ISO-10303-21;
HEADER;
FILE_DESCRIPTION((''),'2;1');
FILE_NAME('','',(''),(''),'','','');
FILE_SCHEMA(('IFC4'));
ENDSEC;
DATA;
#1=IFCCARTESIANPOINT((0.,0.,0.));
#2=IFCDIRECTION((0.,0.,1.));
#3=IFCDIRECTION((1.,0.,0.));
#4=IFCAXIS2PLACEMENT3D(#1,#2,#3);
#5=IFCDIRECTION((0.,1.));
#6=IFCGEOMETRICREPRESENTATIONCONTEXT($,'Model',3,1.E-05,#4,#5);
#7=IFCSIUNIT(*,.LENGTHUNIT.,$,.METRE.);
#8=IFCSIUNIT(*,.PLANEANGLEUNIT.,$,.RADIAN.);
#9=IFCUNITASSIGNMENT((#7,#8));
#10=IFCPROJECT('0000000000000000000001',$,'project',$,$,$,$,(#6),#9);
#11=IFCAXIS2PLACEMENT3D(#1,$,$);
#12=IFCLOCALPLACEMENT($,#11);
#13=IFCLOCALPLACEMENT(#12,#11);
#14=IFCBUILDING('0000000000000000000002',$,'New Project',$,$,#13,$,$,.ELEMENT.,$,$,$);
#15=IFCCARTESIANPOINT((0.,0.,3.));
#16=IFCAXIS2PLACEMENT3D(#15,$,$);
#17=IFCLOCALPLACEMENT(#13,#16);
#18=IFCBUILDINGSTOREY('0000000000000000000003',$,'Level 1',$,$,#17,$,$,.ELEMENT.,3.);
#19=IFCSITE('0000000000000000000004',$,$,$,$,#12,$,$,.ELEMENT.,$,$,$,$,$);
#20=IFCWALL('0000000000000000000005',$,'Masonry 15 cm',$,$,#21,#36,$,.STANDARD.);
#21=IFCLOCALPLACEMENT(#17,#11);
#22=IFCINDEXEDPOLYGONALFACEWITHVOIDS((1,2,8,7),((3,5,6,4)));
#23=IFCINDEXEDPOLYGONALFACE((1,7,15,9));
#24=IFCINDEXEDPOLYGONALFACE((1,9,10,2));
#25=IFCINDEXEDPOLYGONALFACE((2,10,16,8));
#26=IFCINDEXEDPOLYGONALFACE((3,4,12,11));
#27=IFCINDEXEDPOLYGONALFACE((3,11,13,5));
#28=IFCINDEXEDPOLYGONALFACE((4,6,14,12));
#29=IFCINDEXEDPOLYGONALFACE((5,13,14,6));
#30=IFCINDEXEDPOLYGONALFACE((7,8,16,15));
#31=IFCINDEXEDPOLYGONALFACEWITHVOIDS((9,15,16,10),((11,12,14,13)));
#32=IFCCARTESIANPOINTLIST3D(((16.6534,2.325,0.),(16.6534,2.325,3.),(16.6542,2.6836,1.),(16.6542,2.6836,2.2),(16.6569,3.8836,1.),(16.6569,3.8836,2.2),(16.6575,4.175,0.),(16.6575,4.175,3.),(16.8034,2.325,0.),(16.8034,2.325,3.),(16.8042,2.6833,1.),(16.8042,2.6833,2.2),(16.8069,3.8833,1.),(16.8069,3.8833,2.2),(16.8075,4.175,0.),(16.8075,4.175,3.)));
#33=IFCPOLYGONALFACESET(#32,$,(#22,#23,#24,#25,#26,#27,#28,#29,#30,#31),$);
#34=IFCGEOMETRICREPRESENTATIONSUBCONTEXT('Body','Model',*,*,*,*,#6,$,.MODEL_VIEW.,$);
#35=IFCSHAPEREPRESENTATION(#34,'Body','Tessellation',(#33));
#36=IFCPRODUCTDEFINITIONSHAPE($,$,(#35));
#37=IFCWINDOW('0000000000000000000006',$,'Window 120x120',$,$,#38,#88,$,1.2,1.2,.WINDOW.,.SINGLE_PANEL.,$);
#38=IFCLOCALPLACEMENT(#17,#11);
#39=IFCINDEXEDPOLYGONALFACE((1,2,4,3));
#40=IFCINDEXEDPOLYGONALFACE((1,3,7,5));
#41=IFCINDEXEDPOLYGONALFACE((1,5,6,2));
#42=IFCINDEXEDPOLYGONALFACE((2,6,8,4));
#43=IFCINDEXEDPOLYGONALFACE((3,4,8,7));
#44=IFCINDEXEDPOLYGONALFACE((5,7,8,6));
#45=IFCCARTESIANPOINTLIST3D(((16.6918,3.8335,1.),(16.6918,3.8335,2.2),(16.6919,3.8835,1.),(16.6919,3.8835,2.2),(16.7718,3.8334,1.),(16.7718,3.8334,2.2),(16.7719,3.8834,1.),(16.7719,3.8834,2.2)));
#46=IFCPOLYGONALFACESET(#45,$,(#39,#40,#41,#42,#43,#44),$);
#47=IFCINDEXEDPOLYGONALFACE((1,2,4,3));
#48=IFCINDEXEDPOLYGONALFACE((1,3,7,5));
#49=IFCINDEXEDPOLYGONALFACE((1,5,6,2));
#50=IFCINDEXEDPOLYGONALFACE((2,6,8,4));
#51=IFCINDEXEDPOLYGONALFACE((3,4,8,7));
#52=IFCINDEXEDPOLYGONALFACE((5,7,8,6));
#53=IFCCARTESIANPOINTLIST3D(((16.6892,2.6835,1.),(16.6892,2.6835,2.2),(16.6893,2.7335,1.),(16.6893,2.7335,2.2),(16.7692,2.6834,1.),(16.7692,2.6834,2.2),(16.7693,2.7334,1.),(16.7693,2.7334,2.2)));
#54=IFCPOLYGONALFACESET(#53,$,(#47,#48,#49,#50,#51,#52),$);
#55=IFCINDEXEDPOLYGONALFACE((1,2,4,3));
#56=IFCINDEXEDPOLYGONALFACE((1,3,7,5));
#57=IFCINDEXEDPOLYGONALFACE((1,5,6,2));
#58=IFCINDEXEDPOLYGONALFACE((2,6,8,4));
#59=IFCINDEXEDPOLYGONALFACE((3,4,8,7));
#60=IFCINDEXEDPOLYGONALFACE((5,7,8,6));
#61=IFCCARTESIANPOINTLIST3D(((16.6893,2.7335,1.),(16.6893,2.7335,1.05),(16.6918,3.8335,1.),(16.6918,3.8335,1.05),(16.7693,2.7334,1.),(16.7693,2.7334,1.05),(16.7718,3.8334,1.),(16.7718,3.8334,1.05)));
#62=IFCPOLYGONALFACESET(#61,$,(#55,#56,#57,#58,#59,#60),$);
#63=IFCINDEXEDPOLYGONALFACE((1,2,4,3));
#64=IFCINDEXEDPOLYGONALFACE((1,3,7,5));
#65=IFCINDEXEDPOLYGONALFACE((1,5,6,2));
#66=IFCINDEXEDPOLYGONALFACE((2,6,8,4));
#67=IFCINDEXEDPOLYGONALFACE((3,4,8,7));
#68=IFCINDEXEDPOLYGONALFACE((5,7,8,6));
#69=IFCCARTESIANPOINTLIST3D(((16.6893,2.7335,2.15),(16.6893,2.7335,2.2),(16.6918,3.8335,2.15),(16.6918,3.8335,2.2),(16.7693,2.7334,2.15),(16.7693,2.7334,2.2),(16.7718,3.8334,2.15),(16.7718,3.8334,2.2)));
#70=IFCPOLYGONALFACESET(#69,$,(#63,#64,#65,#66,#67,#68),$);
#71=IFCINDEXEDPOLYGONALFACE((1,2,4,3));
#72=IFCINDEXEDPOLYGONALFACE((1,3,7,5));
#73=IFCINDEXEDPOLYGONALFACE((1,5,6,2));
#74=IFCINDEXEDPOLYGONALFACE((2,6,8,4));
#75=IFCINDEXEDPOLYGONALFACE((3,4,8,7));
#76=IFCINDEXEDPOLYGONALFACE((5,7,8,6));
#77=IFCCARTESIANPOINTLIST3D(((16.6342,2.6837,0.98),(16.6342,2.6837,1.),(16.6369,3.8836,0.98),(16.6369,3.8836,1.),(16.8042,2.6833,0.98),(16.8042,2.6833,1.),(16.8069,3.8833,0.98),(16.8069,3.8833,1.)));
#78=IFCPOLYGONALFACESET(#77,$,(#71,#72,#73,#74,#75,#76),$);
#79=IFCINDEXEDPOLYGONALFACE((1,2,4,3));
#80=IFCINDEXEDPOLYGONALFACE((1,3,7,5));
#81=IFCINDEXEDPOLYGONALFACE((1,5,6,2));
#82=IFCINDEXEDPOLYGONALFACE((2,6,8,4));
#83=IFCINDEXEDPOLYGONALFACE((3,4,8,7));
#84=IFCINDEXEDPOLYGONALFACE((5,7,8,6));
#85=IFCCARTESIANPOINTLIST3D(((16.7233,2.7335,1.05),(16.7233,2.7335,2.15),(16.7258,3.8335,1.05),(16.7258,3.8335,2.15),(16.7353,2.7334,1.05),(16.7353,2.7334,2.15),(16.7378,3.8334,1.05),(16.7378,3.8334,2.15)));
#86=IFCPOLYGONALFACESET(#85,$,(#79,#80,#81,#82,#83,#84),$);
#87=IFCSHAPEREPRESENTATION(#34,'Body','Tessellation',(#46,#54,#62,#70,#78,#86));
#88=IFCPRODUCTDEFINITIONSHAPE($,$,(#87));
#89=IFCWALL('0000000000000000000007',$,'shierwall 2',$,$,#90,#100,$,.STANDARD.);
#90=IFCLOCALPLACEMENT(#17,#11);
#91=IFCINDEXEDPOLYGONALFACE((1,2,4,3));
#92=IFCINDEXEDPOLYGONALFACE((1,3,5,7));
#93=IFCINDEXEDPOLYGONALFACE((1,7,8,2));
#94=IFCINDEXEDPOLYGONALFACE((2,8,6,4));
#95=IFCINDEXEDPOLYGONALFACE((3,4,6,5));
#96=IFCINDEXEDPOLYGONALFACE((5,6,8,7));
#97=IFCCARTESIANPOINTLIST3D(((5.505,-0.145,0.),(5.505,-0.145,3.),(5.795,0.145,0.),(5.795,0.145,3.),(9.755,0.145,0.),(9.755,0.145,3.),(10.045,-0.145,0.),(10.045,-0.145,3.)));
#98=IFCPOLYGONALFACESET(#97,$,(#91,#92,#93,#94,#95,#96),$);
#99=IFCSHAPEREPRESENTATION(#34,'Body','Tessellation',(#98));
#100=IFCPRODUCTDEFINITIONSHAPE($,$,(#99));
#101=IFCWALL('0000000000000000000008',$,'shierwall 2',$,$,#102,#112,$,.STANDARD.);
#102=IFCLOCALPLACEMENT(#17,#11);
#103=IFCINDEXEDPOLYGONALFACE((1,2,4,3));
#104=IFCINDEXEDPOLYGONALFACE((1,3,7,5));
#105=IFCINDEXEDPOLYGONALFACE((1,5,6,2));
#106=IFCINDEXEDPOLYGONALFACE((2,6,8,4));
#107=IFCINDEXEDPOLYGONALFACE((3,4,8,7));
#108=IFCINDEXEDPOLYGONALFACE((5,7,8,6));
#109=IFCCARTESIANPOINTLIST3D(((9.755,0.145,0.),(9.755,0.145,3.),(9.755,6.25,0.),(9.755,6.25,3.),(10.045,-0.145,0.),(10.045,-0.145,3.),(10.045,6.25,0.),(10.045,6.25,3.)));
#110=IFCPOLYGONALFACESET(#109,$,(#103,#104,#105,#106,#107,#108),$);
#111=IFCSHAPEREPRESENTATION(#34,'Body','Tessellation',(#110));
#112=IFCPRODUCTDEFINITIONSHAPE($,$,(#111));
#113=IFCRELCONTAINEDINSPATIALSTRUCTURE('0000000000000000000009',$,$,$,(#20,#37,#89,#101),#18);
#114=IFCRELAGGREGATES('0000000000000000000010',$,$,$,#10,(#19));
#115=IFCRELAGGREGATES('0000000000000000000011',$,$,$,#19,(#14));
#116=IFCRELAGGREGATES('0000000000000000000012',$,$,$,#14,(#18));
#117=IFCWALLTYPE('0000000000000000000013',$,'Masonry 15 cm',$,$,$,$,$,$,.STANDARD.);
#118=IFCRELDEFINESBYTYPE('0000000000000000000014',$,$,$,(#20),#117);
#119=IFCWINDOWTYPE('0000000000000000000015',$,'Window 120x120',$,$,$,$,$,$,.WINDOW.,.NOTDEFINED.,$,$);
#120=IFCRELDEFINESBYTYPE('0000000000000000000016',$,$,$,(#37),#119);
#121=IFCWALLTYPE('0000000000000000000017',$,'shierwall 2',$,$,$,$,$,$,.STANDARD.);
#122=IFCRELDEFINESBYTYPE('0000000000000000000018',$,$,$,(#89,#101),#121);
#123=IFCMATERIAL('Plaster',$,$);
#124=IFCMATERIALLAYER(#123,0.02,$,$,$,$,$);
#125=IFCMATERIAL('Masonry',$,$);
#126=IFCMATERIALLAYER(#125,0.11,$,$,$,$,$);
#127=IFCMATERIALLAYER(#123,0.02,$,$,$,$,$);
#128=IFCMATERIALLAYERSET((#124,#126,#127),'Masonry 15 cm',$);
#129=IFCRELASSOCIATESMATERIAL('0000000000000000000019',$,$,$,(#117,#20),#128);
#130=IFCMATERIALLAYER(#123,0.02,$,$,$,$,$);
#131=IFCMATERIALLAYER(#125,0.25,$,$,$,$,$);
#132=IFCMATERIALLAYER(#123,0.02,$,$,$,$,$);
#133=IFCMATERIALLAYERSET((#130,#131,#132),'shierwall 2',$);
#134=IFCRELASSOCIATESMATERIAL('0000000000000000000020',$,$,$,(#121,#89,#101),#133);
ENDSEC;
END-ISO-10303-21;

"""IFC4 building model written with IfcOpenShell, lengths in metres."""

from ifc_helpers import new_model, si_unit, direction, frame, frame_2d, origin, origin_with_axes, place, context, subcontext, project, spatial, polyline, rectangle, outline, extrude, material, layer, layer_set, layer_usage, type_object, element, fill, save


model = new_model("IFC4")

# Units and contexts
model_context = context("Model", 3, precision=1e-05, world=origin_with_axes(), true_north=direction((0.0, 1.0)))
body_context = subcontext(model_context, "Body", "Model", "MODEL_VIEW")
ifc_project = project(units=[si_unit("LENGTHUNIT", "METRE"), si_unit("PLANEANGLEUNIT", "RADIAN")], contexts=[model_context])

# Site, building, storey
site_placement = place(None, origin())
site = spatial("IfcSite", under=ifc_project, at=site_placement, CompositionType="ELEMENT")
building_placement = place(site_placement, origin())
building = spatial("IfcBuilding", under=site, at=building_placement, Name="New Project", CompositionType="ELEMENT")
storey_placement = place(building_placement, frame((0.0, 0.0, 3.0)))
storey = spatial("IfcBuildingStorey", under=building, at=storey_placement, Name="Level 1", CompositionType="ELEMENT", Elevation=3.0)

# Shared definitions
ifc_material_1 = material(Name="Plaster")
ifc_layer_1 = layer(ifc_material_1, 0.02)
ifc_material_2 = material(Name="Masonry")
ifc_layer_2 = layer(ifc_material_2, 0.11)
ifc_layer_3 = layer(ifc_material_1, 0.02)
ifc_layer_set_1 = layer_set([ifc_layer_1, ifc_layer_2, ifc_layer_3], Name="Masonry 15 cm")
ifc_layer_usage_1 = layer_usage(ifc_layer_set_1, "AXIS2", "NEGATIVE", 0.075)
wall_type_1 = type_object("IfcWallType", Name="Masonry 15 cm", PredefinedType="STANDARD", material=ifc_layer_set_1)

# Shared definitions
window_type_1 = type_object("IfcWindowType", Name="Window 120x120", PartitioningType="NOTDEFINED", PredefinedType="WINDOW")

# Wall, opening, window
wall_1_placement = place(storey_placement, frame((16.7283, 2.25, 0.0), z_axis=(0.0, 0.0, 1.0), x_axis=(0.002207, 0.999998, 0.0)))
wall_1 = element("IfcWall", 1, at=wall_1_placement, inside=storey, type_object=wall_type_1, material=ifc_layer_usage_1, Name="Masonry 15 cm", PredefinedType="STANDARD", context=body_context, shape_type="SweptSolid", body=[
    extrude(outline(polyline([(0.0752, -0.075), (1.9252, -0.075), (1.9248, 0.075), (0.0748, 0.075), (0.0752, -0.075)])), origin(), (0.0, 0.0, 1.0), 3.0),
])
opening_1_placement = place(wall_1_placement, frame((0.4334, 0.0, 1.0)))
opening_1 = element("IfcOpeningElement", 2, at=opening_1_placement, cuts=wall_1, PredefinedType="OPENING", context=body_context, shape_type="SweptSolid", body=[
    extrude(rectangle(XDim=1.2, YDim=0.25, at=frame_2d((0.6, 0.0))), origin(), (0.0, 0.0, 1.0), 1.2),
])
window_1_placement = place(opening_1_placement, origin())
window_1 = element("IfcWindow", 3, at=window_1_placement, inside=storey, type_object=window_type_1, Name="Window 120x120", OverallHeight=1.2, OverallWidth=1.2, PartitioningType="SINGLE_PANEL", PredefinedType="WINDOW", context=body_context, shape_type="SweptSolid", body=[
    extrude(outline(polyline([(1.2, 0.04), (1.15, 0.04), (1.15, -0.04), (1.2, -0.04), (1.2, 0.04)])), origin(), (0.0, 0.0, 1.0), 1.2),
    extrude(outline(polyline([(0.05, 0.04), (0.0, 0.04), (0.0, -0.04), (0.05, -0.04), (0.05, 0.04)])), origin(), (0.0, 0.0, 1.0), 1.2),
    extrude(outline(polyline([(1.15, 0.04), (0.05, 0.04), (0.05, -0.04), (1.15, -0.04), (1.15, 0.04)])), origin(), (0.0, 0.0, 1.0), 0.05),
    extrude(outline(polyline([(1.15, 0.04), (0.05, 0.04), (0.05, -0.04), (1.15, -0.04), (1.15, 0.04)])), frame((0.0, 0.0, 1.15)), (0.0, 0.0, 1.0), 0.05),
    extrude(outline(polyline([(1.2, 0.095), (0.0, 0.095), (0.0, -0.075), (1.2, -0.075), (1.2, 0.095)])), frame((0.0, 0.0, -0.02)), (0.0, 0.0, 1.0), 0.02),
    extrude(outline(polyline([(1.15, 0.006), (0.05, 0.006), (0.05, -0.006), (1.15, -0.006), (1.15, 0.006)])), frame((0.0, 0.0, 0.05)), (0.0, 0.0, 1.0), 1.1),
])
fill(opening_1, window_1)

# Walls
ifc_layer_4 = layer(ifc_material_1, 0.02)
ifc_layer_5 = layer(ifc_material_2, 0.25)
ifc_layer_6 = layer(ifc_material_1, 0.02)
ifc_layer_set_2 = layer_set([ifc_layer_4, ifc_layer_5, ifc_layer_6], Name="shierwall 2")
ifc_layer_usage_2 = layer_usage(ifc_layer_set_2, "AXIS2", "NEGATIVE", 0.145)
wall_type_2 = type_object("IfcWallType", Name="shierwall 2", PredefinedType="STANDARD", material=ifc_layer_set_2)
wall_2_placement = place(storey_placement, frame((5.65, 0.0, 0.0)))
element("IfcWall", 4, at=wall_2_placement, inside=storey, type_object=wall_type_2, material=ifc_layer_usage_2, Name="shierwall 2", PredefinedType="STANDARD", context=body_context, shape_type="SweptSolid", body=[
    extrude(outline(polyline([(-0.145, -0.145), (4.395, -0.145), (4.105, 0.145), (0.145, 0.145), (-0.145, -0.145)])), origin(), (0.0, 0.0, 1.0), 3.0),
])
wall_3_placement = place(storey_placement, frame((9.9, 0.0, 0.0), z_axis=(0.0, 0.0, 1.0), x_axis=(0.0, 1.0, 0.0)))
element("IfcWall", 5, at=wall_3_placement, inside=storey, type_object=wall_type_2, material=ifc_layer_usage_2, Name="shierwall 2", PredefinedType="STANDARD", context=body_context, shape_type="SweptSolid", body=[
    extrude(outline(polyline([(-0.145, -0.145), (6.25, -0.145), (6.25, 0.145), (0.145, 0.145), (-0.145, -0.145)])), origin(), (0.0, 0.0, 1.0), 3.0),
])

save(model, "model.ifc")
